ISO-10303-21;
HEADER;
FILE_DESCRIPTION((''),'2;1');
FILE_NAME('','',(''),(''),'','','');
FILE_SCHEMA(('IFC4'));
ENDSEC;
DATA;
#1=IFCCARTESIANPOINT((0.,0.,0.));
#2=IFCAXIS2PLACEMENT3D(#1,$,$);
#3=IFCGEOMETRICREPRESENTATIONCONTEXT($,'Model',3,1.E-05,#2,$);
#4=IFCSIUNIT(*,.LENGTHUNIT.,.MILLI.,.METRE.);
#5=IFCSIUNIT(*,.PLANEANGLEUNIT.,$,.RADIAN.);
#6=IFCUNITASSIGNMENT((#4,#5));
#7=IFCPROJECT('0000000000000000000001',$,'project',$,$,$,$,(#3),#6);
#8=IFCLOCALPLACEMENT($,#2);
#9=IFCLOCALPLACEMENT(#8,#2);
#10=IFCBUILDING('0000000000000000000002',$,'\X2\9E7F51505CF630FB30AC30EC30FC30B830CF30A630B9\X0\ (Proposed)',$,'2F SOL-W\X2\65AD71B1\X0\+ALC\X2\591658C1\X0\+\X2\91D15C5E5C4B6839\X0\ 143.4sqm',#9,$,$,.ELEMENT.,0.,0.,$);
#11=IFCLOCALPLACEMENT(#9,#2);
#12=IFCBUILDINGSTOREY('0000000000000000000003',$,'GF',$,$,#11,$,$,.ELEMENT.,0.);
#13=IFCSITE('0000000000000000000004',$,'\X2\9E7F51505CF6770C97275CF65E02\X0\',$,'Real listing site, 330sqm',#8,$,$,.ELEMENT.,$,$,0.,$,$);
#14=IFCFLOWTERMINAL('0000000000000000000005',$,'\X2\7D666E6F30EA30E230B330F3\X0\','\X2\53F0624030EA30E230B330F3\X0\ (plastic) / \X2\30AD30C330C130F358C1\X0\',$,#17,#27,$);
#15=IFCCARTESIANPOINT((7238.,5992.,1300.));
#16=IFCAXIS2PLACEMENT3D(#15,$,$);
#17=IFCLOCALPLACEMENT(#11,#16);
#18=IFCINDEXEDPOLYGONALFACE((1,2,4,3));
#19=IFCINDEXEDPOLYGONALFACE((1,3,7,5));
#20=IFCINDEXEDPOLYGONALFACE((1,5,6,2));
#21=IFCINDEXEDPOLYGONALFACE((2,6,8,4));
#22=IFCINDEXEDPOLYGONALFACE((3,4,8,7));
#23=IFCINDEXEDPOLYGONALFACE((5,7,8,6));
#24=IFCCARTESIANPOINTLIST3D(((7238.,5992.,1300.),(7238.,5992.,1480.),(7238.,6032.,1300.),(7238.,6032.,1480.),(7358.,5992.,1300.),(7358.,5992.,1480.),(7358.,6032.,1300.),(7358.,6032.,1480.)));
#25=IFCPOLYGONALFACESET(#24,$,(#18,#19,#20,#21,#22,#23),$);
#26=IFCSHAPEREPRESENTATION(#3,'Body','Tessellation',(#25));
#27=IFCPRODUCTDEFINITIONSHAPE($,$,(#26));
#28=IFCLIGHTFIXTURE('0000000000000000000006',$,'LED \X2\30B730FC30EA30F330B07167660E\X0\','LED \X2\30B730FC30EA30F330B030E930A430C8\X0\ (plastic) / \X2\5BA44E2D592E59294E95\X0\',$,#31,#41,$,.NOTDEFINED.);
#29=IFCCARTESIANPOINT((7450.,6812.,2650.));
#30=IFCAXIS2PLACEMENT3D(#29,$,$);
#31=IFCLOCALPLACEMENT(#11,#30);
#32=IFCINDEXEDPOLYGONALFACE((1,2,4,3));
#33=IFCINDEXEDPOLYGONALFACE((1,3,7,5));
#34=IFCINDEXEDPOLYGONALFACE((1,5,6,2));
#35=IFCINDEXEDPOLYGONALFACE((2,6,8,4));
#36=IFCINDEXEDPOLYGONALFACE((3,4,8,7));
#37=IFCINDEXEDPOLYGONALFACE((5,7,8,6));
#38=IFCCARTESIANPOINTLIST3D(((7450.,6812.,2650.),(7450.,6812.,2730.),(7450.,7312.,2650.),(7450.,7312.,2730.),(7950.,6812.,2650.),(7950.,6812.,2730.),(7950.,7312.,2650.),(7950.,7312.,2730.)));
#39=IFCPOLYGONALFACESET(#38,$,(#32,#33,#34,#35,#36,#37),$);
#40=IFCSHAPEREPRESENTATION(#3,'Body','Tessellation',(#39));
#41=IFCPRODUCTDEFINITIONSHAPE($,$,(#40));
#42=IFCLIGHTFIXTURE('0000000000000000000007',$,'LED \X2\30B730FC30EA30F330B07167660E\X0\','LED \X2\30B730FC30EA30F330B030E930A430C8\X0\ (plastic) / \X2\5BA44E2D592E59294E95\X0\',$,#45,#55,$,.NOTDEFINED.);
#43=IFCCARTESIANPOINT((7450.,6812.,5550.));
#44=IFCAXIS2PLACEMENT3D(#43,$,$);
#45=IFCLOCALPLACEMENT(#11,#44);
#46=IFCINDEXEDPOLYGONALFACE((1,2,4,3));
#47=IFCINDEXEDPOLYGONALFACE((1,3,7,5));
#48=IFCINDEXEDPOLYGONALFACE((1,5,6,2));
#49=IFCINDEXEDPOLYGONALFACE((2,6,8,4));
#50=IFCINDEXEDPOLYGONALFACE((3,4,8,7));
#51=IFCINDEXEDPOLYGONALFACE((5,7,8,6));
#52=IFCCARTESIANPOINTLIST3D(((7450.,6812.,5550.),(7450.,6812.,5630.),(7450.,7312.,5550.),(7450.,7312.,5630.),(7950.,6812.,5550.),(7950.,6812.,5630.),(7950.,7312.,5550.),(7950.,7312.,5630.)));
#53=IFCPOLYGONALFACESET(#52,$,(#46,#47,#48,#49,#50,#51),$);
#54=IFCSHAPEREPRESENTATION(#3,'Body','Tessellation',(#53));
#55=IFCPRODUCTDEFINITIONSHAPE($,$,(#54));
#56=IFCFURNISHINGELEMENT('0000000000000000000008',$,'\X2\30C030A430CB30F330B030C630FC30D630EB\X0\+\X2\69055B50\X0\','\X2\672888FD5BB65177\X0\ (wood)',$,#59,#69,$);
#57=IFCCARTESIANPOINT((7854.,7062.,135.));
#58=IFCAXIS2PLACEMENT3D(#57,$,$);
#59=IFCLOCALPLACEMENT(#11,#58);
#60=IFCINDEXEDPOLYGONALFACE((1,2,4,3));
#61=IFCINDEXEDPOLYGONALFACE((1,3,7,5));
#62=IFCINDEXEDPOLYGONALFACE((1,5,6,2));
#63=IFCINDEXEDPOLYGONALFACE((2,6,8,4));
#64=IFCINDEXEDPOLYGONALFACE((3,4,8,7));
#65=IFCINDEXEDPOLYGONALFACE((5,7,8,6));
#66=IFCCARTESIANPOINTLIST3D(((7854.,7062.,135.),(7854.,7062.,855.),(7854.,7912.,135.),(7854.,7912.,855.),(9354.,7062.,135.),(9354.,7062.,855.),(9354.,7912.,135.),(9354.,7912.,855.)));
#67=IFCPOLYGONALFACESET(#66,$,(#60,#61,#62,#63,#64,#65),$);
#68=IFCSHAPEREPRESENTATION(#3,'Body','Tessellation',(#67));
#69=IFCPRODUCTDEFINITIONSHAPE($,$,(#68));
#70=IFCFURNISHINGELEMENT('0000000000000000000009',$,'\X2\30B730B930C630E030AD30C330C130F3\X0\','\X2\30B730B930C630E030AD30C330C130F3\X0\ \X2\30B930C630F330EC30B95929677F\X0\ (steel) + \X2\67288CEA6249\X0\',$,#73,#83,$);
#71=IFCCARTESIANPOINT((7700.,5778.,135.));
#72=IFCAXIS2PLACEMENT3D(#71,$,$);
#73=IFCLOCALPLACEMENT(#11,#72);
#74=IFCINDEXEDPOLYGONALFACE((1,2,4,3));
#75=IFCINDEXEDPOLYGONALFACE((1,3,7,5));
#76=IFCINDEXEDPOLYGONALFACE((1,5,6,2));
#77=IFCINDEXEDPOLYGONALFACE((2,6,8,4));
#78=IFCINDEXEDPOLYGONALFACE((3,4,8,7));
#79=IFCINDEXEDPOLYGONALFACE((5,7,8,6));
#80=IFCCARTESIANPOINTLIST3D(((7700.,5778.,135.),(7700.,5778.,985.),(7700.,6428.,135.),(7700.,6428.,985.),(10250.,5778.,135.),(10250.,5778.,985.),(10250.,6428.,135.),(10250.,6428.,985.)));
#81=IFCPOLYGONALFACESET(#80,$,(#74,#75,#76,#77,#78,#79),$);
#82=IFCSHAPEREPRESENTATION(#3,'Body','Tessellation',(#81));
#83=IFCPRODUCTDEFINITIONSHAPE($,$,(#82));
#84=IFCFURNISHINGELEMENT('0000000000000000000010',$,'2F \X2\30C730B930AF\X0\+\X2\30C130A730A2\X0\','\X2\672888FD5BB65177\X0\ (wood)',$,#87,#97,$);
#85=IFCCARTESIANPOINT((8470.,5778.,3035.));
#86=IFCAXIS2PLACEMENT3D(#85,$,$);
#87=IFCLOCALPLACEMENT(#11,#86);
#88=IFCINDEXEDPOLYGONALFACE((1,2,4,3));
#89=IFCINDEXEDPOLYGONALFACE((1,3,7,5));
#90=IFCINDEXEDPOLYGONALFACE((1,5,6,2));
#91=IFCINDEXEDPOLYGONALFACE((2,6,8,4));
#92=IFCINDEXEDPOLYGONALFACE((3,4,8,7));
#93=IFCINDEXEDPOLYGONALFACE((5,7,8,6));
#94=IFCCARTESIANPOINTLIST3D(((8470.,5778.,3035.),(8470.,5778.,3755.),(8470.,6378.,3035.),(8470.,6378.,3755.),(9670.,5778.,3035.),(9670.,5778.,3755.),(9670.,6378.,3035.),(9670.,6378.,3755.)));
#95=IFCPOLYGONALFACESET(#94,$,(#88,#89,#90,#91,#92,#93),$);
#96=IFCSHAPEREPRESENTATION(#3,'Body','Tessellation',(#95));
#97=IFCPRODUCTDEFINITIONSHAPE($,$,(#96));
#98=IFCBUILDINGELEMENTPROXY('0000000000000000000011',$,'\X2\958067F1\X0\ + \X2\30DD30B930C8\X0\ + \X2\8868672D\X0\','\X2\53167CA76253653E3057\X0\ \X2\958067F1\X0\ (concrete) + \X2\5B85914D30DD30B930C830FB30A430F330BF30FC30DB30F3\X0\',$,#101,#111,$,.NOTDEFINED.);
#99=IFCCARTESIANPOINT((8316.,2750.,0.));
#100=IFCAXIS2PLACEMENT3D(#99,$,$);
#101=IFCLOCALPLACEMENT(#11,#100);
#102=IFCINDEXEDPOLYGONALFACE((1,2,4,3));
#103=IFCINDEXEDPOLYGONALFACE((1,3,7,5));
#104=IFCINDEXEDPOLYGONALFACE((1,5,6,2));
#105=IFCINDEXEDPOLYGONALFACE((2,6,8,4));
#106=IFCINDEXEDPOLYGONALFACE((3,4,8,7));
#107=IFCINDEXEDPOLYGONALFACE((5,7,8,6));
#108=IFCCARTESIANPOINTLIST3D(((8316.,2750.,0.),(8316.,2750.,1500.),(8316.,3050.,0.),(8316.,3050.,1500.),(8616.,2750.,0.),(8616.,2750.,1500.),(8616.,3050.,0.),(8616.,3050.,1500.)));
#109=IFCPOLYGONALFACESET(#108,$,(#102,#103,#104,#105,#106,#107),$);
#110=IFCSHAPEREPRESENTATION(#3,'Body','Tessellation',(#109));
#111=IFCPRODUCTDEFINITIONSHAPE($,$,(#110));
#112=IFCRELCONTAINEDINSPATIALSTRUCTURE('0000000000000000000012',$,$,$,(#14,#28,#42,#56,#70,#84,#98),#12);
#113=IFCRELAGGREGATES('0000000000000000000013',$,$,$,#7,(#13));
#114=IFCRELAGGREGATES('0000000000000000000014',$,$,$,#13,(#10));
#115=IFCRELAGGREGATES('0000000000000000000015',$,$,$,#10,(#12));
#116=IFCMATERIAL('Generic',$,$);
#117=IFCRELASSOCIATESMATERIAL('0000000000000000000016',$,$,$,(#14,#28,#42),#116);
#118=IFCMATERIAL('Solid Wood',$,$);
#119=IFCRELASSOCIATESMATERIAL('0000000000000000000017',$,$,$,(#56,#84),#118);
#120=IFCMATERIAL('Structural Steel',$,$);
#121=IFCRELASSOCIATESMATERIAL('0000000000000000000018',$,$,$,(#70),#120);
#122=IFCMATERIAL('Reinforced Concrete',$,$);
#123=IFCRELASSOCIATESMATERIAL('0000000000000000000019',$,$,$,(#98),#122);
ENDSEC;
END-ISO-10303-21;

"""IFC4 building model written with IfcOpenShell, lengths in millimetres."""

from ifc_helpers import new_model, si_unit, frame, frame_2d, origin, place, context, project, spatial, rectangle, extrude, material, element, save


model = new_model("IFC4")

# Units and contexts
model_context = context("Model", 3, precision=1e-05, world=origin())
ifc_project = project(units=[si_unit("LENGTHUNIT", "METRE", prefix="MILLI"), si_unit("PLANEANGLEUNIT", "RADIAN")], contexts=[model_context])

# Site, building, storey
site_placement = place(None, origin())
site = spatial("IfcSite", under=ifc_project, at=site_placement, Name="鹿児島県霧島市", ObjectType="Real listing site, 330sqm", CompositionType="ELEMENT", RefElevation=0.0)
building_placement = place(site_placement, origin())
building = spatial("IfcBuilding", under=site, at=building_placement, Name="鹿児島・ガレージハウス (Proposed)", ObjectType="2F SOL-W断熱+ALC外壁+金属屋根 143.4sqm", CompositionType="ELEMENT", ElevationOfRefHeight=0.0, ElevationOfTerrain=0.0)
storey_placement = place(building_placement, origin())
storey = spatial("IfcBuildingStorey", under=building, at=storey_placement, Name="GF", CompositionType="ELEMENT", Elevation=0.0)

# Shared definitions
ifc_material_1 = material(Name="Solid Wood")

# Shared definitions
ifc_material_2 = material(Name="Structural Steel")

# Shared definitions
ifc_material_3 = material(Name="Reinforced Concrete")

# Flow terminal
ifc_material_4 = material(Name="Generic")
flow_terminal_1_placement = place(storey_placement, frame((7238.0, 5992.0, 1300.0)))
element("IfcFlowTerminal", 1, at=flow_terminal_1_placement, inside=storey, material=ifc_material_4, Name="給湯リモコン", Description="台所リモコン (plastic) / キッチン壁", context=model_context, shape_type="SweptSolid", body=[
    extrude(rectangle(XDim=120.0, YDim=40.0, at=frame_2d((60.0, 20.0))), frame((7238.0, 5992.0, 1300.0)), (0.0, 0.0, 1.0), 180.0),
])

# Light fixtures
light_fixture_1_placement = place(storey_placement, frame((7450.0, 6812.0, 2650.0)))
element("IfcLightFixture", 2, at=light_fixture_1_placement, inside=storey, material=ifc_material_4, Name="LED シーリング照明", Description="LED シーリングライト (plastic) / 室中央天井", PredefinedType="NOTDEFINED", context=model_context, shape_type="SweptSolid", body=[
    extrude(rectangle(XDim=500.0, YDim=500.0, at=frame_2d((250.0, 250.0))), frame((7450.0, 6812.0, 2650.0)), (0.0, 0.0, 1.0), 80.0),
])
light_fixture_2_placement = place(storey_placement, frame((7450.0, 6812.0, 5550.0)))
element("IfcLightFixture", 3, at=light_fixture_2_placement, inside=storey, material=ifc_material_4, Name="LED シーリング照明", Description="LED シーリングライト (plastic) / 室中央天井", PredefinedType="NOTDEFINED", context=model_context, shape_type="SweptSolid", body=[
    extrude(rectangle(XDim=500.0, YDim=500.0, at=frame_2d((250.0, 250.0))), frame((7450.0, 6812.0, 5550.0)), (0.0, 0.0, 1.0), 80.0),
])

# Furnishing elements
furnishing_1_placement = place(storey_placement, frame((7854.0, 7062.0, 135.0)))
element("IfcFurnishingElement", 4, at=furnishing_1_placement, inside=storey, material=ifc_material_1, Name="ダイニングテーブル+椅子", Description="木製家具 (wood)", context=model_context, shape_type="SweptSolid", body=[
    extrude(rectangle(XDim=1500.0, YDim=850.0, at=frame_2d((750.0, 425.0))), frame((7854.0, 7062.0, 135.0)), (0.0, 0.0, 1.0), 720.0),
])
furnishing_2_placement = place(storey_placement, frame((7700.0, 5778.0, 135.0)))
element("IfcFurnishingElement", 5, at=furnishing_2_placement, inside=storey, material=ifc_material_2, Name="システムキッチン", Description="システムキッチン ステンレス天板 (steel) + 木質扉", context=model_context, shape_type="SweptSolid", body=[
    extrude(rectangle(XDim=2550.0, YDim=650.0, at=frame_2d((1275.0, 325.0))), frame((7700.0, 5778.0, 135.0)), (0.0, 0.0, 1.0), 850.0),
])
furnishing_3_placement = place(storey_placement, frame((8470.0, 5778.0, 3035.0)))
element("IfcFurnishingElement", 6, at=furnishing_3_placement, inside=storey, material=ifc_material_1, Name="2F デスク+チェア", Description="木製家具 (wood)", context=model_context, shape_type="SweptSolid", body=[
    extrude(rectangle(XDim=1200.0, YDim=600.0, at=frame_2d((600.0, 300.0))), frame((8470.0, 5778.0, 3035.0)), (0.0, 0.0, 1.0), 720.0),
])

# Building element proxy
proxy_placement = place(storey_placement, frame((8316.0, 2750.0, 0.0)))
element("IfcBuildingElementProxy", 7, at=proxy_placement, inside=storey, material=ifc_material_3, Name="門柱 + ポスト + 表札", Description="化粧打放し 門柱 (concrete) + 宅配ポスト・インターホン", PredefinedType="NOTDEFINED", context=model_context, shape_type="SweptSolid", body=[
    extrude(rectangle(XDim=300.0, YDim=300.0, at=frame_2d((150.0, 150.0))), frame((8316.0, 2750.0, 0.0)), (0.0, 0.0, 1.0), 1500.0),
])

save(model, "model.ifc")
